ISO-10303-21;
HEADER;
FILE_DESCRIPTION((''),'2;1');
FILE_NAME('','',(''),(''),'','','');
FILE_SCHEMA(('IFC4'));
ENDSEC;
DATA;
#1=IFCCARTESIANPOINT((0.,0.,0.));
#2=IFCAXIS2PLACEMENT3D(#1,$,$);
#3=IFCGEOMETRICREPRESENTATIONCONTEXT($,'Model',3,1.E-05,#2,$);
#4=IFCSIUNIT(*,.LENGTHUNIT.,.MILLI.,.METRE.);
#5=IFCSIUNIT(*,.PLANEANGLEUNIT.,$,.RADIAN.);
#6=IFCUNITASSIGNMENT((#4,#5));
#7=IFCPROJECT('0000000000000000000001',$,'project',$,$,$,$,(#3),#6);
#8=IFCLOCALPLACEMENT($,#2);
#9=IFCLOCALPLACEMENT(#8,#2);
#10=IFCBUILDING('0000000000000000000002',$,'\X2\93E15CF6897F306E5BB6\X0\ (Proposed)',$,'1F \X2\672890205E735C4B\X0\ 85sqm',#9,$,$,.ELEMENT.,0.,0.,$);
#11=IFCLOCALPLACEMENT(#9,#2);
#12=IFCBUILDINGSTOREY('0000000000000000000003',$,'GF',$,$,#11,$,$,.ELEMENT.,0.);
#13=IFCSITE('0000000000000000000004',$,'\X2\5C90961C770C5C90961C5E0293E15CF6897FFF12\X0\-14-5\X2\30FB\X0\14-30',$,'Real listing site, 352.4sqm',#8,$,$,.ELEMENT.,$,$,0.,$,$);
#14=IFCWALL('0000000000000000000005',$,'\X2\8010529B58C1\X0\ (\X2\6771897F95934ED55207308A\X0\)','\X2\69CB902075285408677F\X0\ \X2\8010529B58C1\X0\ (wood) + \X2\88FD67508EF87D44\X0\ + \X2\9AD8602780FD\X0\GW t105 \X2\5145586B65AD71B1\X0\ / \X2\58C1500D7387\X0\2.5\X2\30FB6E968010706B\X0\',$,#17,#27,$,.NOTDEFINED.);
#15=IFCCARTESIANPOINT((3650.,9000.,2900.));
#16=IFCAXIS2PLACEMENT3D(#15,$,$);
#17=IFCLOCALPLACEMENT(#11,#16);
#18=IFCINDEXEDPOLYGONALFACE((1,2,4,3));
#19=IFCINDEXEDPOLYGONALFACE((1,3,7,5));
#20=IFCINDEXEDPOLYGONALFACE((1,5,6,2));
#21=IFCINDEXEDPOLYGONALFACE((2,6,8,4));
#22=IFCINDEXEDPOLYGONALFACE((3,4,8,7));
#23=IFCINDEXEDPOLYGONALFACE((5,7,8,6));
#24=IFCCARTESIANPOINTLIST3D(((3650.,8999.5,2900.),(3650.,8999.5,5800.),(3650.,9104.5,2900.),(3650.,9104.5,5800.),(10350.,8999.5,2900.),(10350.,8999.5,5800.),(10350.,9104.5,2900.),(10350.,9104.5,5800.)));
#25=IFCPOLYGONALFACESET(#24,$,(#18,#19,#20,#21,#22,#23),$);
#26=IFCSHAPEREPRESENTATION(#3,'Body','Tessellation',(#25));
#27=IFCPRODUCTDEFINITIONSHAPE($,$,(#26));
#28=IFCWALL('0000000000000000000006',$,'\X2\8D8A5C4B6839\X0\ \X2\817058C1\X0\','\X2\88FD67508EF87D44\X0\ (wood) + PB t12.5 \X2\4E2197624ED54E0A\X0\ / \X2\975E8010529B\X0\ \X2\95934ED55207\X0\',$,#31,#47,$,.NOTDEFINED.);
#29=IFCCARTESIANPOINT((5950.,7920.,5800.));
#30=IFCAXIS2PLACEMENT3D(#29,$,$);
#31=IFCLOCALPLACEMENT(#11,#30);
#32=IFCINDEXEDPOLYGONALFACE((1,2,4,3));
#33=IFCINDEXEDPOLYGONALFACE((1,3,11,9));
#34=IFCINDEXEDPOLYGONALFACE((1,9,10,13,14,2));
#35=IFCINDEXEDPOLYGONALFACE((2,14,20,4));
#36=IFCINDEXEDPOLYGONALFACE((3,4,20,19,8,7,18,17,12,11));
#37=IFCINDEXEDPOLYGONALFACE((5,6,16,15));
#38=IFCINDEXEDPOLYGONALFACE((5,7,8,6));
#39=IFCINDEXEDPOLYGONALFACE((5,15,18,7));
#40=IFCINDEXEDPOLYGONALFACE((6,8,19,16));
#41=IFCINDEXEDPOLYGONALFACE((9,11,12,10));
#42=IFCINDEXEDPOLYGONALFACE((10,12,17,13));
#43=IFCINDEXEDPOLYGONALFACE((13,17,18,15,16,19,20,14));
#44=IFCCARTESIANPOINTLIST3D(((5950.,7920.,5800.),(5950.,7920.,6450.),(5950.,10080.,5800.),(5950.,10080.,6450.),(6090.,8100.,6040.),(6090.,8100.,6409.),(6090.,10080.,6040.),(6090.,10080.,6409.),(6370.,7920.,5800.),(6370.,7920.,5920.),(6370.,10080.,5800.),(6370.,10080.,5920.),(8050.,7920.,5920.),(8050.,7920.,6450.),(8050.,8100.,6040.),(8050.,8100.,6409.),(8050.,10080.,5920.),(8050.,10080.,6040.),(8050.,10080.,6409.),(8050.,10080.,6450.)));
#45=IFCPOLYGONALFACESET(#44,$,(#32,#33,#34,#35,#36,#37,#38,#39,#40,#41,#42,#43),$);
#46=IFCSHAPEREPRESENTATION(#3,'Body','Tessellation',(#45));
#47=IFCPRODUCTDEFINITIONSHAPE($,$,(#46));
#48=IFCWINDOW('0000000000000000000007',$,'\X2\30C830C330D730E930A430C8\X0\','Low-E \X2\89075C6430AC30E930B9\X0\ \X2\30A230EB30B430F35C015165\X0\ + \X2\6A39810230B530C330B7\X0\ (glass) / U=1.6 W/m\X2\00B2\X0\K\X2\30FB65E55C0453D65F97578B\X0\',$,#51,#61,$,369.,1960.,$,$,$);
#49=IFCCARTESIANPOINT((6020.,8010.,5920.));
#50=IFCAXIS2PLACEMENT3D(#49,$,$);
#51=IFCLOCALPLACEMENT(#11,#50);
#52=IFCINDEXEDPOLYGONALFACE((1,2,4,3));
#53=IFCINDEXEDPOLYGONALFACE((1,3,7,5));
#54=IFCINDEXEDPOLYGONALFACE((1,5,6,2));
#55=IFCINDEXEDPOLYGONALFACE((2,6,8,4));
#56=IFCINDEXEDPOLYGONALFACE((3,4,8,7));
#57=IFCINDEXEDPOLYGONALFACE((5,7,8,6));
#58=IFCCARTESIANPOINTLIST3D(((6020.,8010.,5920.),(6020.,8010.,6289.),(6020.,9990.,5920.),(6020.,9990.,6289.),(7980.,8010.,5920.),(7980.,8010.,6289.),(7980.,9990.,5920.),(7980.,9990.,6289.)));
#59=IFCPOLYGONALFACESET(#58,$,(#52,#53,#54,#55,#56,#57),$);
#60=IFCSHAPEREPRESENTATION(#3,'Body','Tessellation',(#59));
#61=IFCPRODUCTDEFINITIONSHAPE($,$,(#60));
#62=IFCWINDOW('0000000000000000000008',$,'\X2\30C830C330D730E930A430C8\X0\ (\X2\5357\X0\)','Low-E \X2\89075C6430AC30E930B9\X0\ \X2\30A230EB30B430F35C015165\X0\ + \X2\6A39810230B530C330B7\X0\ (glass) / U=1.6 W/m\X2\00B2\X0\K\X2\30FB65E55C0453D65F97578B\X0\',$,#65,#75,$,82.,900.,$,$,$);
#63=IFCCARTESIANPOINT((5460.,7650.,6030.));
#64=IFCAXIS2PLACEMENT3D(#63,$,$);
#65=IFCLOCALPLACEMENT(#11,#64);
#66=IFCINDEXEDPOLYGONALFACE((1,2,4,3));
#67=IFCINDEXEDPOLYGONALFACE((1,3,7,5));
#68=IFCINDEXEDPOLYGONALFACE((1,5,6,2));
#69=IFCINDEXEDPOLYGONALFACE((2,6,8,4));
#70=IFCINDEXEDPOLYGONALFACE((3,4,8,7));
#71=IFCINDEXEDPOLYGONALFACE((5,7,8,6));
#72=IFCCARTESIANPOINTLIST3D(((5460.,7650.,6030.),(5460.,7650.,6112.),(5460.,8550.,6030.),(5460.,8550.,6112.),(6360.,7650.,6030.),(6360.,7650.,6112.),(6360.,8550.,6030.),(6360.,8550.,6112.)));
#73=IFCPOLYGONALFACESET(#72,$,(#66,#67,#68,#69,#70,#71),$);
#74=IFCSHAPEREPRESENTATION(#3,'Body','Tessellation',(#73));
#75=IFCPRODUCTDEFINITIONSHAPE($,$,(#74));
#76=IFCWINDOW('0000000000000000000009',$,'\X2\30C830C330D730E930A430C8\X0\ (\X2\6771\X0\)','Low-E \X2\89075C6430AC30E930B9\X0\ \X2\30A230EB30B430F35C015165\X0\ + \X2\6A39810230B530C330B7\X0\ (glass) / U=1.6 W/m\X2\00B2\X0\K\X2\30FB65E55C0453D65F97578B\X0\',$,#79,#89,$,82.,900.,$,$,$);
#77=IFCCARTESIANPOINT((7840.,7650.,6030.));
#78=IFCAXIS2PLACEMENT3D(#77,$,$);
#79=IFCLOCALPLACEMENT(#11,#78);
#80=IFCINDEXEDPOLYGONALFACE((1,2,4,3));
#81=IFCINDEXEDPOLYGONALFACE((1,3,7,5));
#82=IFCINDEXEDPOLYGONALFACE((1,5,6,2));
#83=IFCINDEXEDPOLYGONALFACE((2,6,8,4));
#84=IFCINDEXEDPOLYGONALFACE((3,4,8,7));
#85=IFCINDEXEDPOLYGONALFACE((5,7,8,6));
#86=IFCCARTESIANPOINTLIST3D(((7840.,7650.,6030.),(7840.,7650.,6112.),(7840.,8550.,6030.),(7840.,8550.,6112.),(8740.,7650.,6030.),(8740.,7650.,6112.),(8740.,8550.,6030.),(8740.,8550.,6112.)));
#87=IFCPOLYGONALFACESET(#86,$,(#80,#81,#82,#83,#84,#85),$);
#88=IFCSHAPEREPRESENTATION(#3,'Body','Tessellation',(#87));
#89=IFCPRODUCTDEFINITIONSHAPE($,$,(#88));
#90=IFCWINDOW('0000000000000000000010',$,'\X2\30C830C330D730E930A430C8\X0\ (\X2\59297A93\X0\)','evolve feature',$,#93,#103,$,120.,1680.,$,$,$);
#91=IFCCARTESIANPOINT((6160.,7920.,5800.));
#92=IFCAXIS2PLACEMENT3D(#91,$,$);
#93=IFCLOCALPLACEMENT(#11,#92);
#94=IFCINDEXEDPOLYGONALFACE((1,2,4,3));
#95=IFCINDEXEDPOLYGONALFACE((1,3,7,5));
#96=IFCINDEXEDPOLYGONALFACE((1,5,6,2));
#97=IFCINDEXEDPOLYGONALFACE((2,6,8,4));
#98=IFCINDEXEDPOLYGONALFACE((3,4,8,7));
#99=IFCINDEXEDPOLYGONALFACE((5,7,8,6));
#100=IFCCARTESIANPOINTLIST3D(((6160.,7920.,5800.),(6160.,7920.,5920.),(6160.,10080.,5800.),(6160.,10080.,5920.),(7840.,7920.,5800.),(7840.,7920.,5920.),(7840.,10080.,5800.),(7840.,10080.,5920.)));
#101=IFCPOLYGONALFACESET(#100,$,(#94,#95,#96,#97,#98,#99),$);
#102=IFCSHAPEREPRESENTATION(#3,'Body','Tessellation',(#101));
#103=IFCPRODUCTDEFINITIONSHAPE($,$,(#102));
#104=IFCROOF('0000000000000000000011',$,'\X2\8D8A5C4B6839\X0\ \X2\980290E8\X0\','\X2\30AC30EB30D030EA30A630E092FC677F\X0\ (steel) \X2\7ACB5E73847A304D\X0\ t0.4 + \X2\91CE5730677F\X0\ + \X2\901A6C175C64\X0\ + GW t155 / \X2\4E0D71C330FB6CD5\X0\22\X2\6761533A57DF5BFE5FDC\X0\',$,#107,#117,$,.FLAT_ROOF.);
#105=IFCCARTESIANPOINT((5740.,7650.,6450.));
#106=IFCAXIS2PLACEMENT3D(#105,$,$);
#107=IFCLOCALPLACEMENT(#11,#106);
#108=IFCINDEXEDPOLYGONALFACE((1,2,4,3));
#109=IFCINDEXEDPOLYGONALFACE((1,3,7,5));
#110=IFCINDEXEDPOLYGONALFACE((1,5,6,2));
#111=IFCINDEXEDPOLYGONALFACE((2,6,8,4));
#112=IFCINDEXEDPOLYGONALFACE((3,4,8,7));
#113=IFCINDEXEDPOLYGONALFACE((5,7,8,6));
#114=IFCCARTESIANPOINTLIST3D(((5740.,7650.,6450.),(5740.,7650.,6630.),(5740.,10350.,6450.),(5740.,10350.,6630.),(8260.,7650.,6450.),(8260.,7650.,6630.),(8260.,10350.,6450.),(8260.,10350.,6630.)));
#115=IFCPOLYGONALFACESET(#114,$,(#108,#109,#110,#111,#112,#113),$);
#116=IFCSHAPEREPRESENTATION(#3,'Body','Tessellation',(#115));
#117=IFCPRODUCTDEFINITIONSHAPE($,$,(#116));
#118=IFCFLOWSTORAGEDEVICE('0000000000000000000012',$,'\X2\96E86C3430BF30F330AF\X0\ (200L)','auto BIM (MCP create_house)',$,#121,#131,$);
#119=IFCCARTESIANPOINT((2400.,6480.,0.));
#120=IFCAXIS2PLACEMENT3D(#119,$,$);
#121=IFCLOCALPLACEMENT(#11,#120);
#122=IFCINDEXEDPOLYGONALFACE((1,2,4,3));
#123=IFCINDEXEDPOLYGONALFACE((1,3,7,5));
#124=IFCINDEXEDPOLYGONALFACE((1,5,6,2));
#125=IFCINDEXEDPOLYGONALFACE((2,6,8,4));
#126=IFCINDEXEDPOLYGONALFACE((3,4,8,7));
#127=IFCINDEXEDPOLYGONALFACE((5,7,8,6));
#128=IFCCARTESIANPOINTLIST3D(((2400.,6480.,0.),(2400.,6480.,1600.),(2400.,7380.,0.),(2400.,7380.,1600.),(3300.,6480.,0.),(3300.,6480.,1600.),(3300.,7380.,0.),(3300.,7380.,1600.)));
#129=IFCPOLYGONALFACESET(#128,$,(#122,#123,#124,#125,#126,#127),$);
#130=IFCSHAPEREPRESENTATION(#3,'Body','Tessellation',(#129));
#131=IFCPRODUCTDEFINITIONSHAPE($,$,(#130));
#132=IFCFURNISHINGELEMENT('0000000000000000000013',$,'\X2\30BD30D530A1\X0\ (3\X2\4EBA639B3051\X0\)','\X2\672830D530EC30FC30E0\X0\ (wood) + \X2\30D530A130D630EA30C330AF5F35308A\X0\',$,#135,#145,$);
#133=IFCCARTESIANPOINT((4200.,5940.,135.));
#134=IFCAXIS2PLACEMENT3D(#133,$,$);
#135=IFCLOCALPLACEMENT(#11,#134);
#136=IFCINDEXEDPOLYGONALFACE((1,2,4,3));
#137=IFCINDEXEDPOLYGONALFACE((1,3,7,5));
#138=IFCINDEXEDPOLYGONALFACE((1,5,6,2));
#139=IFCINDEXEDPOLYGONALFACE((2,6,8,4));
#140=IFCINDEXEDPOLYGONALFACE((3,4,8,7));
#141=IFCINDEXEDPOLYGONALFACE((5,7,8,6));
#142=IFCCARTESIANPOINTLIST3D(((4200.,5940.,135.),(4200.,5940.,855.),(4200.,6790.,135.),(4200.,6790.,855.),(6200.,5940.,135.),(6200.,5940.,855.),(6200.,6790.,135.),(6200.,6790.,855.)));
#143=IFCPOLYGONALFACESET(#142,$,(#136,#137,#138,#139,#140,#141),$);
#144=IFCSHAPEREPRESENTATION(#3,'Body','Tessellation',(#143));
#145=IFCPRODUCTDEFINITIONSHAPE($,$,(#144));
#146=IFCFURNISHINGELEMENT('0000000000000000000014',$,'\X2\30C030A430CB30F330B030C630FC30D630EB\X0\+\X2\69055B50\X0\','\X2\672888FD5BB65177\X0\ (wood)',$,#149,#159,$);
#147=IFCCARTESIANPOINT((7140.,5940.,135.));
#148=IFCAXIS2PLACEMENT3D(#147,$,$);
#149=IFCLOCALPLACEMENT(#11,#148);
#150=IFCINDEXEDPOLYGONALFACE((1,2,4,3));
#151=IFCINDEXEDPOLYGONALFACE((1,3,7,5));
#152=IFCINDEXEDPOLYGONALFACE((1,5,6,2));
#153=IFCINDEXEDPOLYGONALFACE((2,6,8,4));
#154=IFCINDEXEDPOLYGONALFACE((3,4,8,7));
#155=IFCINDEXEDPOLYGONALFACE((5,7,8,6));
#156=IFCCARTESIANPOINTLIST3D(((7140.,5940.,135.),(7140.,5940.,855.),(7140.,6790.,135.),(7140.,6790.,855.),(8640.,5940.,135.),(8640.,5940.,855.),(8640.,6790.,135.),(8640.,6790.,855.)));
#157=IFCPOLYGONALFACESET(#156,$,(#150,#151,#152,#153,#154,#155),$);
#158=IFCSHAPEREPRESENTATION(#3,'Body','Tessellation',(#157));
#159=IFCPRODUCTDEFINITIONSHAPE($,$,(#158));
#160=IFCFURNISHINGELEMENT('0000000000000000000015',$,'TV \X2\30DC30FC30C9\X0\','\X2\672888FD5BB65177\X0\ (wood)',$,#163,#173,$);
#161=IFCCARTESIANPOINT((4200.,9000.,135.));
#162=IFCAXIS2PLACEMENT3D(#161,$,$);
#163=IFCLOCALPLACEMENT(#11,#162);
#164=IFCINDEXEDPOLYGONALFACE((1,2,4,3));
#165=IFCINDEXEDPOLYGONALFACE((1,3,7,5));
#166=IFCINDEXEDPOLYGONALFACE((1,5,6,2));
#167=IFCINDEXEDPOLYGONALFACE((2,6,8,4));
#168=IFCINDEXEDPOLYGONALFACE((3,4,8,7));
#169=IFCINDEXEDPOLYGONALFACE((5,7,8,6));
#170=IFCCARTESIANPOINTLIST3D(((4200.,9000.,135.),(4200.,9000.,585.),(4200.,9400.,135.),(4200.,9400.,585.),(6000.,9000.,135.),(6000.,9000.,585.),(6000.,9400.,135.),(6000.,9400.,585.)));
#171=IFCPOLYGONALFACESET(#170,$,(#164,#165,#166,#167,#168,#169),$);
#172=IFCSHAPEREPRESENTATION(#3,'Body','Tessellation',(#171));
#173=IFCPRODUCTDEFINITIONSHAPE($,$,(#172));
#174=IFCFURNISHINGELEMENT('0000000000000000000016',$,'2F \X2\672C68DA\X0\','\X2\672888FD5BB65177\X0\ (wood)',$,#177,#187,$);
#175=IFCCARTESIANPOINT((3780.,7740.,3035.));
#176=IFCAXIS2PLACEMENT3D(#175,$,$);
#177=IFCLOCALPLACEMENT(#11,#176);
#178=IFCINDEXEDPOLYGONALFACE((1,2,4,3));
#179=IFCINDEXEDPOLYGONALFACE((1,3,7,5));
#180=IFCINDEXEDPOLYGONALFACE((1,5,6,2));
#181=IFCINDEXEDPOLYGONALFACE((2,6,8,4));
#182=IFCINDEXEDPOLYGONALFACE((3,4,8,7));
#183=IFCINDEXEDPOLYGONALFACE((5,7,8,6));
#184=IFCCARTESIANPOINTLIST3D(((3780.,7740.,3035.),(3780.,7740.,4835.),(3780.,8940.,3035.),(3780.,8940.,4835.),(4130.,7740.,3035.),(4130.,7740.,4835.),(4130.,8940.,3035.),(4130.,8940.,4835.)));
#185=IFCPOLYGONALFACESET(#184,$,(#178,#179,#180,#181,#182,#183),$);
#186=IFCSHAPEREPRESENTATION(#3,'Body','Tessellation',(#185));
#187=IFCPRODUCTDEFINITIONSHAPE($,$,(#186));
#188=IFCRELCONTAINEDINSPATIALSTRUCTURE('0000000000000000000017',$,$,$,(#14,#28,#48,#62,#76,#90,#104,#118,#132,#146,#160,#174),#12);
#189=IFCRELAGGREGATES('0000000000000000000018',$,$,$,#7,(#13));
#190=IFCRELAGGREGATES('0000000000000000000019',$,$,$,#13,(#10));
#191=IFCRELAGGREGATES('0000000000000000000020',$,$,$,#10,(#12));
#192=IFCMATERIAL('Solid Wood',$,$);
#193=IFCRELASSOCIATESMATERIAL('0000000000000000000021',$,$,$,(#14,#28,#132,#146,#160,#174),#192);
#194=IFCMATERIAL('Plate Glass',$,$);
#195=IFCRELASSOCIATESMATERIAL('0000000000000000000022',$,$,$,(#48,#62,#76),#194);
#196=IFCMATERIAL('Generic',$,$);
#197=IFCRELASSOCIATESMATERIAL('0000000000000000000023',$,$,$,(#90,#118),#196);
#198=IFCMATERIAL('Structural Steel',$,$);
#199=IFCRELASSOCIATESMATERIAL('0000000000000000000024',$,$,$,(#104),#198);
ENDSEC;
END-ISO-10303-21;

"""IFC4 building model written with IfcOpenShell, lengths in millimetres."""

from ifc_helpers import new_model, si_unit, frame, frame_2d, origin, place, context, project, spatial, rectangle, extrude, material, element, fill, save


model = new_model("IFC4")

# Units and contexts
model_context = context("Model", 3, precision=1e-05, world=origin())
ifc_project = project(units=[si_unit("LENGTHUNIT", "METRE", prefix="MILLI"), si_unit("PLANEANGLEUNIT", "RADIAN")], contexts=[model_context])

# Site, building, storey
site_placement = place(None, origin())
site = spatial("IfcSite", under=ifc_project, at=site_placement, Name="岐阜県岐阜市鏡島西２-14-5・14-30", ObjectType="Real listing site, 352.4sqm", CompositionType="ELEMENT", RefElevation=0.0)
building_placement = place(site_placement, origin())
building = spatial("IfcBuilding", under=site, at=building_placement, Name="鏡島西の家 (Proposed)", ObjectType="1F 木造平屋 85sqm", CompositionType="ELEMENT", ElevationOfRefHeight=0.0, ElevationOfTerrain=0.0)
storey_placement = place(building_placement, origin())
storey = spatial("IfcBuildingStorey", under=building, at=storey_placement, Name="GF", CompositionType="ELEMENT", Elevation=0.0)

# Wall
ifc_material_1 = material(Name="Solid Wood")
wall_1_placement = place(storey_placement, frame((3650.0, 9000.0, 2900.0)))
element("IfcWall", 1, at=wall_1_placement, inside=storey, material=ifc_material_1, Name="耐力壁 (東西間仕切り)", Description="構造用合板 耐力壁 (wood) + 製材軸組 + 高性能GW t105 充填断熱 / 壁倍率2.5・準耐火", PredefinedType="NOTDEFINED", context=model_context, shape_type="SweptSolid", body=[
    extrude(rectangle(XDim=6700.0, YDim=105.0, at=frame_2d((3350.0, 52.0))), frame((3650.0, 9000.0, 2900.0)), (0.0, 0.0, 1.0), 2900.0),
])

# Wall, openings, windows
wall_2_placement = place(storey_placement, frame((5950.0, 7920.0, 5800.0)))
wall_2 = element("IfcWall", 2, at=wall_2_placement, inside=storey, material=ifc_material_1, Name="越屋根 腰壁", Description="製材軸組 (wood) + PB t12.5 両面仕上 / 非耐力 間仕切", PredefinedType="NOTDEFINED", context=model_context, shape_type="SweptSolid", body=[
    extrude(rectangle(XDim=2100.0, YDim=2160.0, at=frame_2d((1050.0, 1080.0))), frame((5950.0, 7920.0, 5800.0)), (0.0, 0.0, 1.0), 650.0),
])
opening_1_placement = place(storey_placement, frame((6020.0, 8010.0, 5920.0)))
opening_1 = element("IfcOpeningElement", 3, at=opening_1_placement, cuts=wall_2, PredefinedType="NOTDEFINED", context=model_context, shape_type="SweptSolid", body=[
    extrude(rectangle(XDim=1960.0, YDim=1980.0, at=frame_2d((980.0, 990.0))), frame((6020.0, 8010.0, 5920.0)), (0.0, 0.0, 1.0), 369.0),
])
opening_2_placement = place(storey_placement, frame((5460.0, 7650.0, 6030.0)))
opening_2 = element("IfcOpeningElement", 4, at=opening_2_placement, cuts=wall_2, PredefinedType="NOTDEFINED", context=model_context, shape_type="SweptSolid", body=[
    extrude(rectangle(XDim=900.0, YDim=900.0, at=frame_2d((450.0, 450.0))), frame((5460.0, 7650.0, 6030.0)), (0.0, 0.0, 1.0), 82.0),
])
opening_3_placement = place(storey_placement, frame((7840.0, 7650.0, 6030.0)))
opening_3 = element("IfcOpeningElement", 5, at=opening_3_placement, cuts=wall_2, PredefinedType="NOTDEFINED", context=model_context, shape_type="SweptSolid", body=[
    extrude(rectangle(XDim=900.0, YDim=900.0, at=frame_2d((450.0, 450.0))), frame((7840.0, 7650.0, 6030.0)), (0.0, 0.0, 1.0), 82.0),
])
opening_4_placement = place(storey_placement, frame((6160.0, 7920.0, 5800.0)))
opening_4 = element("IfcOpeningElement", 6, at=opening_4_placement, cuts=wall_2, PredefinedType="NOTDEFINED", context=model_context, shape_type="SweptSolid", body=[
    extrude(rectangle(XDim=1680.0, YDim=2160.0, at=frame_2d((840.0, 1080.0))), frame((6160.0, 7920.0, 5800.0)), (0.0, 0.0, 1.0), 120.0),
])
ifc_material_2 = material(Name="Plate Glass")
window_1_placement = place(storey_placement, frame((6020.0, 8010.0, 5920.0)))
window_1 = element("IfcWindow", 7, at=window_1_placement, inside=storey, material=ifc_material_2, Name="トップライト", Description="Low-E 複層ガラス アルゴン封入 + 樹脂サッシ (glass) / U=1.6 W/m²K・日射取得型", OverallHeight=369.0, OverallWidth=1960.0, context=model_context, shape_type="SweptSolid", body=[
    extrude(rectangle(XDim=1960.0, YDim=1980.0, at=frame_2d((980.0, 990.0))), frame((6020.0, 8010.0, 5920.0)), (0.0, 0.0, 1.0), 369.0),
])
fill(opening_1, window_1)
window_2_placement = place(storey_placement, frame((5460.0, 7650.0, 6030.0)))
window_2 = element("IfcWindow", 8, at=window_2_placement, inside=storey, material=ifc_material_2, Name="トップライト (南)", Description="Low-E 複層ガラス アルゴン封入 + 樹脂サッシ (glass) / U=1.6 W/m²K・日射取得型", OverallHeight=82.0, OverallWidth=900.0, context=model_context, shape_type="SweptSolid", body=[
    extrude(rectangle(XDim=900.0, YDim=900.0, at=frame_2d((450.0, 450.0))), frame((5460.0, 7650.0, 6030.0)), (0.0, 0.0, 1.0), 82.0),
])
fill(opening_2, window_2)
window_3_placement = place(storey_placement, frame((7840.0, 7650.0, 6030.0)))
window_3 = element("IfcWindow", 9, at=window_3_placement, inside=storey, material=ifc_material_2, Name="トップライト (東)", Description="Low-E 複層ガラス アルゴン封入 + 樹脂サッシ (glass) / U=1.6 W/m²K・日射取得型", OverallHeight=82.0, OverallWidth=900.0, context=model_context, shape_type="SweptSolid", body=[
    extrude(rectangle(XDim=900.0, YDim=900.0, at=frame_2d((450.0, 450.0))), frame((7840.0, 7650.0, 6030.0)), (0.0, 0.0, 1.0), 82.0),
])
fill(opening_3, window_3)
ifc_material_3 = material(Name="Generic")
window_4_placement = place(storey_placement, frame((6160.0, 7920.0, 5800.0)))
window_4 = element("IfcWindow", 10, at=window_4_placement, inside=storey, material=ifc_material_3, Name="トップライト (天窓)", Description="evolve feature", OverallHeight=120.0, OverallWidth=1680.0, context=model_context, shape_type="SweptSolid", body=[
    extrude(rectangle(XDim=1680.0, YDim=2160.0, at=frame_2d((840.0, 1080.0))), frame((6160.0, 7920.0, 5800.0)), (0.0, 0.0, 1.0), 120.0),
])
fill(opening_4, window_4)

# Roof
ifc_material_4 = material(Name="Structural Steel")
roof_placement = place(storey_placement, frame((5740.0, 7650.0, 6450.0)))
element("IfcRoof", 11, at=roof_placement, inside=storey, material=ifc_material_4, Name="越屋根 頂部", Description="ガルバリウム鋼板 (steel) 立平葺き t0.4 + 野地板 + 通気層 + GW t155 / 不燃・法22条区域対応", PredefinedType="FLAT_ROOF", context=model_context, shape_type="SweptSolid", body=[
    extrude(rectangle(XDim=2520.0, YDim=2700.0, at=frame_2d((1260.0, 1350.0))), frame((5740.0, 7650.0, 6450.0)), (0.0, 0.0, 1.0), 180.0),
])

# Flow storage device
flow_storage_device_placement = place(storey_placement, frame((2400.0, 6480.0, 0.0)))
element("IfcFlowStorageDevice", 12, at=flow_storage_device_placement, inside=storey, material=ifc_material_3, Name="雨水タンク (200L)", Description="auto BIM (MCP create_house)", context=model_context, shape_type="SweptSolid", body=[
    extrude(rectangle(XDim=900.0, YDim=900.0, at=frame_2d((450.0, 450.0))), frame((2400.0, 6480.0, 0.0)), (0.0, 0.0, 1.0), 1600.0),
])

# Furnishing elements
furnishing_1_placement = place(storey_placement, frame((4200.0, 5940.0, 135.0)))
element("IfcFurnishingElement", 13, at=furnishing_1_placement, inside=storey, material=ifc_material_1, Name="ソファ (3人掛け)", Description="木フレーム (wood) + ファブリック張り", context=model_context, shape_type="SweptSolid", body=[
    extrude(rectangle(XDim=2000.0, YDim=850.0, at=frame_2d((1000.0, 425.0))), frame((4200.0, 5940.0, 135.0)), (0.0, 0.0, 1.0), 720.0),
])
furnishing_2_placement = place(storey_placement, frame((7140.0, 5940.0, 135.0)))
element("IfcFurnishingElement", 14, at=furnishing_2_placement, inside=storey, material=ifc_material_1, Name="ダイニングテーブル+椅子", Description="木製家具 (wood)", context=model_context, shape_type="SweptSolid", body=[
    extrude(rectangle(XDim=1500.0, YDim=850.0, at=frame_2d((750.0, 425.0))), frame((7140.0, 5940.0, 135.0)), (0.0, 0.0, 1.0), 720.0),
])
furnishing_3_placement = place(storey_placement, frame((4200.0, 9000.0, 135.0)))
element("IfcFurnishingElement", 15, at=furnishing_3_placement, inside=storey, material=ifc_material_1, Name="TV ボード", Description="木製家具 (wood)", context=model_context, shape_type="SweptSolid", body=[
    extrude(rectangle(XDim=1800.0, YDim=400.0, at=frame_2d((900.0, 200.0))), frame((4200.0, 9000.0, 135.0)), (0.0, 0.0, 1.0), 450.0),
])
furnishing_4_placement = place(storey_placement, frame((3780.0, 7740.0, 3035.0)))
element("IfcFurnishingElement", 16, at=furnishing_4_placement, inside=storey, material=ifc_material_1, Name="2F 本棚", Description="木製家具 (wood)", context=model_context, shape_type="SweptSolid", body=[
    extrude(rectangle(XDim=350.0, YDim=1200.0, at=frame_2d((175.0, 600.0))), frame((3780.0, 7740.0, 3035.0)), (0.0, 0.0, 1.0), 1800.0),
])

save(model, "model.ifc")
